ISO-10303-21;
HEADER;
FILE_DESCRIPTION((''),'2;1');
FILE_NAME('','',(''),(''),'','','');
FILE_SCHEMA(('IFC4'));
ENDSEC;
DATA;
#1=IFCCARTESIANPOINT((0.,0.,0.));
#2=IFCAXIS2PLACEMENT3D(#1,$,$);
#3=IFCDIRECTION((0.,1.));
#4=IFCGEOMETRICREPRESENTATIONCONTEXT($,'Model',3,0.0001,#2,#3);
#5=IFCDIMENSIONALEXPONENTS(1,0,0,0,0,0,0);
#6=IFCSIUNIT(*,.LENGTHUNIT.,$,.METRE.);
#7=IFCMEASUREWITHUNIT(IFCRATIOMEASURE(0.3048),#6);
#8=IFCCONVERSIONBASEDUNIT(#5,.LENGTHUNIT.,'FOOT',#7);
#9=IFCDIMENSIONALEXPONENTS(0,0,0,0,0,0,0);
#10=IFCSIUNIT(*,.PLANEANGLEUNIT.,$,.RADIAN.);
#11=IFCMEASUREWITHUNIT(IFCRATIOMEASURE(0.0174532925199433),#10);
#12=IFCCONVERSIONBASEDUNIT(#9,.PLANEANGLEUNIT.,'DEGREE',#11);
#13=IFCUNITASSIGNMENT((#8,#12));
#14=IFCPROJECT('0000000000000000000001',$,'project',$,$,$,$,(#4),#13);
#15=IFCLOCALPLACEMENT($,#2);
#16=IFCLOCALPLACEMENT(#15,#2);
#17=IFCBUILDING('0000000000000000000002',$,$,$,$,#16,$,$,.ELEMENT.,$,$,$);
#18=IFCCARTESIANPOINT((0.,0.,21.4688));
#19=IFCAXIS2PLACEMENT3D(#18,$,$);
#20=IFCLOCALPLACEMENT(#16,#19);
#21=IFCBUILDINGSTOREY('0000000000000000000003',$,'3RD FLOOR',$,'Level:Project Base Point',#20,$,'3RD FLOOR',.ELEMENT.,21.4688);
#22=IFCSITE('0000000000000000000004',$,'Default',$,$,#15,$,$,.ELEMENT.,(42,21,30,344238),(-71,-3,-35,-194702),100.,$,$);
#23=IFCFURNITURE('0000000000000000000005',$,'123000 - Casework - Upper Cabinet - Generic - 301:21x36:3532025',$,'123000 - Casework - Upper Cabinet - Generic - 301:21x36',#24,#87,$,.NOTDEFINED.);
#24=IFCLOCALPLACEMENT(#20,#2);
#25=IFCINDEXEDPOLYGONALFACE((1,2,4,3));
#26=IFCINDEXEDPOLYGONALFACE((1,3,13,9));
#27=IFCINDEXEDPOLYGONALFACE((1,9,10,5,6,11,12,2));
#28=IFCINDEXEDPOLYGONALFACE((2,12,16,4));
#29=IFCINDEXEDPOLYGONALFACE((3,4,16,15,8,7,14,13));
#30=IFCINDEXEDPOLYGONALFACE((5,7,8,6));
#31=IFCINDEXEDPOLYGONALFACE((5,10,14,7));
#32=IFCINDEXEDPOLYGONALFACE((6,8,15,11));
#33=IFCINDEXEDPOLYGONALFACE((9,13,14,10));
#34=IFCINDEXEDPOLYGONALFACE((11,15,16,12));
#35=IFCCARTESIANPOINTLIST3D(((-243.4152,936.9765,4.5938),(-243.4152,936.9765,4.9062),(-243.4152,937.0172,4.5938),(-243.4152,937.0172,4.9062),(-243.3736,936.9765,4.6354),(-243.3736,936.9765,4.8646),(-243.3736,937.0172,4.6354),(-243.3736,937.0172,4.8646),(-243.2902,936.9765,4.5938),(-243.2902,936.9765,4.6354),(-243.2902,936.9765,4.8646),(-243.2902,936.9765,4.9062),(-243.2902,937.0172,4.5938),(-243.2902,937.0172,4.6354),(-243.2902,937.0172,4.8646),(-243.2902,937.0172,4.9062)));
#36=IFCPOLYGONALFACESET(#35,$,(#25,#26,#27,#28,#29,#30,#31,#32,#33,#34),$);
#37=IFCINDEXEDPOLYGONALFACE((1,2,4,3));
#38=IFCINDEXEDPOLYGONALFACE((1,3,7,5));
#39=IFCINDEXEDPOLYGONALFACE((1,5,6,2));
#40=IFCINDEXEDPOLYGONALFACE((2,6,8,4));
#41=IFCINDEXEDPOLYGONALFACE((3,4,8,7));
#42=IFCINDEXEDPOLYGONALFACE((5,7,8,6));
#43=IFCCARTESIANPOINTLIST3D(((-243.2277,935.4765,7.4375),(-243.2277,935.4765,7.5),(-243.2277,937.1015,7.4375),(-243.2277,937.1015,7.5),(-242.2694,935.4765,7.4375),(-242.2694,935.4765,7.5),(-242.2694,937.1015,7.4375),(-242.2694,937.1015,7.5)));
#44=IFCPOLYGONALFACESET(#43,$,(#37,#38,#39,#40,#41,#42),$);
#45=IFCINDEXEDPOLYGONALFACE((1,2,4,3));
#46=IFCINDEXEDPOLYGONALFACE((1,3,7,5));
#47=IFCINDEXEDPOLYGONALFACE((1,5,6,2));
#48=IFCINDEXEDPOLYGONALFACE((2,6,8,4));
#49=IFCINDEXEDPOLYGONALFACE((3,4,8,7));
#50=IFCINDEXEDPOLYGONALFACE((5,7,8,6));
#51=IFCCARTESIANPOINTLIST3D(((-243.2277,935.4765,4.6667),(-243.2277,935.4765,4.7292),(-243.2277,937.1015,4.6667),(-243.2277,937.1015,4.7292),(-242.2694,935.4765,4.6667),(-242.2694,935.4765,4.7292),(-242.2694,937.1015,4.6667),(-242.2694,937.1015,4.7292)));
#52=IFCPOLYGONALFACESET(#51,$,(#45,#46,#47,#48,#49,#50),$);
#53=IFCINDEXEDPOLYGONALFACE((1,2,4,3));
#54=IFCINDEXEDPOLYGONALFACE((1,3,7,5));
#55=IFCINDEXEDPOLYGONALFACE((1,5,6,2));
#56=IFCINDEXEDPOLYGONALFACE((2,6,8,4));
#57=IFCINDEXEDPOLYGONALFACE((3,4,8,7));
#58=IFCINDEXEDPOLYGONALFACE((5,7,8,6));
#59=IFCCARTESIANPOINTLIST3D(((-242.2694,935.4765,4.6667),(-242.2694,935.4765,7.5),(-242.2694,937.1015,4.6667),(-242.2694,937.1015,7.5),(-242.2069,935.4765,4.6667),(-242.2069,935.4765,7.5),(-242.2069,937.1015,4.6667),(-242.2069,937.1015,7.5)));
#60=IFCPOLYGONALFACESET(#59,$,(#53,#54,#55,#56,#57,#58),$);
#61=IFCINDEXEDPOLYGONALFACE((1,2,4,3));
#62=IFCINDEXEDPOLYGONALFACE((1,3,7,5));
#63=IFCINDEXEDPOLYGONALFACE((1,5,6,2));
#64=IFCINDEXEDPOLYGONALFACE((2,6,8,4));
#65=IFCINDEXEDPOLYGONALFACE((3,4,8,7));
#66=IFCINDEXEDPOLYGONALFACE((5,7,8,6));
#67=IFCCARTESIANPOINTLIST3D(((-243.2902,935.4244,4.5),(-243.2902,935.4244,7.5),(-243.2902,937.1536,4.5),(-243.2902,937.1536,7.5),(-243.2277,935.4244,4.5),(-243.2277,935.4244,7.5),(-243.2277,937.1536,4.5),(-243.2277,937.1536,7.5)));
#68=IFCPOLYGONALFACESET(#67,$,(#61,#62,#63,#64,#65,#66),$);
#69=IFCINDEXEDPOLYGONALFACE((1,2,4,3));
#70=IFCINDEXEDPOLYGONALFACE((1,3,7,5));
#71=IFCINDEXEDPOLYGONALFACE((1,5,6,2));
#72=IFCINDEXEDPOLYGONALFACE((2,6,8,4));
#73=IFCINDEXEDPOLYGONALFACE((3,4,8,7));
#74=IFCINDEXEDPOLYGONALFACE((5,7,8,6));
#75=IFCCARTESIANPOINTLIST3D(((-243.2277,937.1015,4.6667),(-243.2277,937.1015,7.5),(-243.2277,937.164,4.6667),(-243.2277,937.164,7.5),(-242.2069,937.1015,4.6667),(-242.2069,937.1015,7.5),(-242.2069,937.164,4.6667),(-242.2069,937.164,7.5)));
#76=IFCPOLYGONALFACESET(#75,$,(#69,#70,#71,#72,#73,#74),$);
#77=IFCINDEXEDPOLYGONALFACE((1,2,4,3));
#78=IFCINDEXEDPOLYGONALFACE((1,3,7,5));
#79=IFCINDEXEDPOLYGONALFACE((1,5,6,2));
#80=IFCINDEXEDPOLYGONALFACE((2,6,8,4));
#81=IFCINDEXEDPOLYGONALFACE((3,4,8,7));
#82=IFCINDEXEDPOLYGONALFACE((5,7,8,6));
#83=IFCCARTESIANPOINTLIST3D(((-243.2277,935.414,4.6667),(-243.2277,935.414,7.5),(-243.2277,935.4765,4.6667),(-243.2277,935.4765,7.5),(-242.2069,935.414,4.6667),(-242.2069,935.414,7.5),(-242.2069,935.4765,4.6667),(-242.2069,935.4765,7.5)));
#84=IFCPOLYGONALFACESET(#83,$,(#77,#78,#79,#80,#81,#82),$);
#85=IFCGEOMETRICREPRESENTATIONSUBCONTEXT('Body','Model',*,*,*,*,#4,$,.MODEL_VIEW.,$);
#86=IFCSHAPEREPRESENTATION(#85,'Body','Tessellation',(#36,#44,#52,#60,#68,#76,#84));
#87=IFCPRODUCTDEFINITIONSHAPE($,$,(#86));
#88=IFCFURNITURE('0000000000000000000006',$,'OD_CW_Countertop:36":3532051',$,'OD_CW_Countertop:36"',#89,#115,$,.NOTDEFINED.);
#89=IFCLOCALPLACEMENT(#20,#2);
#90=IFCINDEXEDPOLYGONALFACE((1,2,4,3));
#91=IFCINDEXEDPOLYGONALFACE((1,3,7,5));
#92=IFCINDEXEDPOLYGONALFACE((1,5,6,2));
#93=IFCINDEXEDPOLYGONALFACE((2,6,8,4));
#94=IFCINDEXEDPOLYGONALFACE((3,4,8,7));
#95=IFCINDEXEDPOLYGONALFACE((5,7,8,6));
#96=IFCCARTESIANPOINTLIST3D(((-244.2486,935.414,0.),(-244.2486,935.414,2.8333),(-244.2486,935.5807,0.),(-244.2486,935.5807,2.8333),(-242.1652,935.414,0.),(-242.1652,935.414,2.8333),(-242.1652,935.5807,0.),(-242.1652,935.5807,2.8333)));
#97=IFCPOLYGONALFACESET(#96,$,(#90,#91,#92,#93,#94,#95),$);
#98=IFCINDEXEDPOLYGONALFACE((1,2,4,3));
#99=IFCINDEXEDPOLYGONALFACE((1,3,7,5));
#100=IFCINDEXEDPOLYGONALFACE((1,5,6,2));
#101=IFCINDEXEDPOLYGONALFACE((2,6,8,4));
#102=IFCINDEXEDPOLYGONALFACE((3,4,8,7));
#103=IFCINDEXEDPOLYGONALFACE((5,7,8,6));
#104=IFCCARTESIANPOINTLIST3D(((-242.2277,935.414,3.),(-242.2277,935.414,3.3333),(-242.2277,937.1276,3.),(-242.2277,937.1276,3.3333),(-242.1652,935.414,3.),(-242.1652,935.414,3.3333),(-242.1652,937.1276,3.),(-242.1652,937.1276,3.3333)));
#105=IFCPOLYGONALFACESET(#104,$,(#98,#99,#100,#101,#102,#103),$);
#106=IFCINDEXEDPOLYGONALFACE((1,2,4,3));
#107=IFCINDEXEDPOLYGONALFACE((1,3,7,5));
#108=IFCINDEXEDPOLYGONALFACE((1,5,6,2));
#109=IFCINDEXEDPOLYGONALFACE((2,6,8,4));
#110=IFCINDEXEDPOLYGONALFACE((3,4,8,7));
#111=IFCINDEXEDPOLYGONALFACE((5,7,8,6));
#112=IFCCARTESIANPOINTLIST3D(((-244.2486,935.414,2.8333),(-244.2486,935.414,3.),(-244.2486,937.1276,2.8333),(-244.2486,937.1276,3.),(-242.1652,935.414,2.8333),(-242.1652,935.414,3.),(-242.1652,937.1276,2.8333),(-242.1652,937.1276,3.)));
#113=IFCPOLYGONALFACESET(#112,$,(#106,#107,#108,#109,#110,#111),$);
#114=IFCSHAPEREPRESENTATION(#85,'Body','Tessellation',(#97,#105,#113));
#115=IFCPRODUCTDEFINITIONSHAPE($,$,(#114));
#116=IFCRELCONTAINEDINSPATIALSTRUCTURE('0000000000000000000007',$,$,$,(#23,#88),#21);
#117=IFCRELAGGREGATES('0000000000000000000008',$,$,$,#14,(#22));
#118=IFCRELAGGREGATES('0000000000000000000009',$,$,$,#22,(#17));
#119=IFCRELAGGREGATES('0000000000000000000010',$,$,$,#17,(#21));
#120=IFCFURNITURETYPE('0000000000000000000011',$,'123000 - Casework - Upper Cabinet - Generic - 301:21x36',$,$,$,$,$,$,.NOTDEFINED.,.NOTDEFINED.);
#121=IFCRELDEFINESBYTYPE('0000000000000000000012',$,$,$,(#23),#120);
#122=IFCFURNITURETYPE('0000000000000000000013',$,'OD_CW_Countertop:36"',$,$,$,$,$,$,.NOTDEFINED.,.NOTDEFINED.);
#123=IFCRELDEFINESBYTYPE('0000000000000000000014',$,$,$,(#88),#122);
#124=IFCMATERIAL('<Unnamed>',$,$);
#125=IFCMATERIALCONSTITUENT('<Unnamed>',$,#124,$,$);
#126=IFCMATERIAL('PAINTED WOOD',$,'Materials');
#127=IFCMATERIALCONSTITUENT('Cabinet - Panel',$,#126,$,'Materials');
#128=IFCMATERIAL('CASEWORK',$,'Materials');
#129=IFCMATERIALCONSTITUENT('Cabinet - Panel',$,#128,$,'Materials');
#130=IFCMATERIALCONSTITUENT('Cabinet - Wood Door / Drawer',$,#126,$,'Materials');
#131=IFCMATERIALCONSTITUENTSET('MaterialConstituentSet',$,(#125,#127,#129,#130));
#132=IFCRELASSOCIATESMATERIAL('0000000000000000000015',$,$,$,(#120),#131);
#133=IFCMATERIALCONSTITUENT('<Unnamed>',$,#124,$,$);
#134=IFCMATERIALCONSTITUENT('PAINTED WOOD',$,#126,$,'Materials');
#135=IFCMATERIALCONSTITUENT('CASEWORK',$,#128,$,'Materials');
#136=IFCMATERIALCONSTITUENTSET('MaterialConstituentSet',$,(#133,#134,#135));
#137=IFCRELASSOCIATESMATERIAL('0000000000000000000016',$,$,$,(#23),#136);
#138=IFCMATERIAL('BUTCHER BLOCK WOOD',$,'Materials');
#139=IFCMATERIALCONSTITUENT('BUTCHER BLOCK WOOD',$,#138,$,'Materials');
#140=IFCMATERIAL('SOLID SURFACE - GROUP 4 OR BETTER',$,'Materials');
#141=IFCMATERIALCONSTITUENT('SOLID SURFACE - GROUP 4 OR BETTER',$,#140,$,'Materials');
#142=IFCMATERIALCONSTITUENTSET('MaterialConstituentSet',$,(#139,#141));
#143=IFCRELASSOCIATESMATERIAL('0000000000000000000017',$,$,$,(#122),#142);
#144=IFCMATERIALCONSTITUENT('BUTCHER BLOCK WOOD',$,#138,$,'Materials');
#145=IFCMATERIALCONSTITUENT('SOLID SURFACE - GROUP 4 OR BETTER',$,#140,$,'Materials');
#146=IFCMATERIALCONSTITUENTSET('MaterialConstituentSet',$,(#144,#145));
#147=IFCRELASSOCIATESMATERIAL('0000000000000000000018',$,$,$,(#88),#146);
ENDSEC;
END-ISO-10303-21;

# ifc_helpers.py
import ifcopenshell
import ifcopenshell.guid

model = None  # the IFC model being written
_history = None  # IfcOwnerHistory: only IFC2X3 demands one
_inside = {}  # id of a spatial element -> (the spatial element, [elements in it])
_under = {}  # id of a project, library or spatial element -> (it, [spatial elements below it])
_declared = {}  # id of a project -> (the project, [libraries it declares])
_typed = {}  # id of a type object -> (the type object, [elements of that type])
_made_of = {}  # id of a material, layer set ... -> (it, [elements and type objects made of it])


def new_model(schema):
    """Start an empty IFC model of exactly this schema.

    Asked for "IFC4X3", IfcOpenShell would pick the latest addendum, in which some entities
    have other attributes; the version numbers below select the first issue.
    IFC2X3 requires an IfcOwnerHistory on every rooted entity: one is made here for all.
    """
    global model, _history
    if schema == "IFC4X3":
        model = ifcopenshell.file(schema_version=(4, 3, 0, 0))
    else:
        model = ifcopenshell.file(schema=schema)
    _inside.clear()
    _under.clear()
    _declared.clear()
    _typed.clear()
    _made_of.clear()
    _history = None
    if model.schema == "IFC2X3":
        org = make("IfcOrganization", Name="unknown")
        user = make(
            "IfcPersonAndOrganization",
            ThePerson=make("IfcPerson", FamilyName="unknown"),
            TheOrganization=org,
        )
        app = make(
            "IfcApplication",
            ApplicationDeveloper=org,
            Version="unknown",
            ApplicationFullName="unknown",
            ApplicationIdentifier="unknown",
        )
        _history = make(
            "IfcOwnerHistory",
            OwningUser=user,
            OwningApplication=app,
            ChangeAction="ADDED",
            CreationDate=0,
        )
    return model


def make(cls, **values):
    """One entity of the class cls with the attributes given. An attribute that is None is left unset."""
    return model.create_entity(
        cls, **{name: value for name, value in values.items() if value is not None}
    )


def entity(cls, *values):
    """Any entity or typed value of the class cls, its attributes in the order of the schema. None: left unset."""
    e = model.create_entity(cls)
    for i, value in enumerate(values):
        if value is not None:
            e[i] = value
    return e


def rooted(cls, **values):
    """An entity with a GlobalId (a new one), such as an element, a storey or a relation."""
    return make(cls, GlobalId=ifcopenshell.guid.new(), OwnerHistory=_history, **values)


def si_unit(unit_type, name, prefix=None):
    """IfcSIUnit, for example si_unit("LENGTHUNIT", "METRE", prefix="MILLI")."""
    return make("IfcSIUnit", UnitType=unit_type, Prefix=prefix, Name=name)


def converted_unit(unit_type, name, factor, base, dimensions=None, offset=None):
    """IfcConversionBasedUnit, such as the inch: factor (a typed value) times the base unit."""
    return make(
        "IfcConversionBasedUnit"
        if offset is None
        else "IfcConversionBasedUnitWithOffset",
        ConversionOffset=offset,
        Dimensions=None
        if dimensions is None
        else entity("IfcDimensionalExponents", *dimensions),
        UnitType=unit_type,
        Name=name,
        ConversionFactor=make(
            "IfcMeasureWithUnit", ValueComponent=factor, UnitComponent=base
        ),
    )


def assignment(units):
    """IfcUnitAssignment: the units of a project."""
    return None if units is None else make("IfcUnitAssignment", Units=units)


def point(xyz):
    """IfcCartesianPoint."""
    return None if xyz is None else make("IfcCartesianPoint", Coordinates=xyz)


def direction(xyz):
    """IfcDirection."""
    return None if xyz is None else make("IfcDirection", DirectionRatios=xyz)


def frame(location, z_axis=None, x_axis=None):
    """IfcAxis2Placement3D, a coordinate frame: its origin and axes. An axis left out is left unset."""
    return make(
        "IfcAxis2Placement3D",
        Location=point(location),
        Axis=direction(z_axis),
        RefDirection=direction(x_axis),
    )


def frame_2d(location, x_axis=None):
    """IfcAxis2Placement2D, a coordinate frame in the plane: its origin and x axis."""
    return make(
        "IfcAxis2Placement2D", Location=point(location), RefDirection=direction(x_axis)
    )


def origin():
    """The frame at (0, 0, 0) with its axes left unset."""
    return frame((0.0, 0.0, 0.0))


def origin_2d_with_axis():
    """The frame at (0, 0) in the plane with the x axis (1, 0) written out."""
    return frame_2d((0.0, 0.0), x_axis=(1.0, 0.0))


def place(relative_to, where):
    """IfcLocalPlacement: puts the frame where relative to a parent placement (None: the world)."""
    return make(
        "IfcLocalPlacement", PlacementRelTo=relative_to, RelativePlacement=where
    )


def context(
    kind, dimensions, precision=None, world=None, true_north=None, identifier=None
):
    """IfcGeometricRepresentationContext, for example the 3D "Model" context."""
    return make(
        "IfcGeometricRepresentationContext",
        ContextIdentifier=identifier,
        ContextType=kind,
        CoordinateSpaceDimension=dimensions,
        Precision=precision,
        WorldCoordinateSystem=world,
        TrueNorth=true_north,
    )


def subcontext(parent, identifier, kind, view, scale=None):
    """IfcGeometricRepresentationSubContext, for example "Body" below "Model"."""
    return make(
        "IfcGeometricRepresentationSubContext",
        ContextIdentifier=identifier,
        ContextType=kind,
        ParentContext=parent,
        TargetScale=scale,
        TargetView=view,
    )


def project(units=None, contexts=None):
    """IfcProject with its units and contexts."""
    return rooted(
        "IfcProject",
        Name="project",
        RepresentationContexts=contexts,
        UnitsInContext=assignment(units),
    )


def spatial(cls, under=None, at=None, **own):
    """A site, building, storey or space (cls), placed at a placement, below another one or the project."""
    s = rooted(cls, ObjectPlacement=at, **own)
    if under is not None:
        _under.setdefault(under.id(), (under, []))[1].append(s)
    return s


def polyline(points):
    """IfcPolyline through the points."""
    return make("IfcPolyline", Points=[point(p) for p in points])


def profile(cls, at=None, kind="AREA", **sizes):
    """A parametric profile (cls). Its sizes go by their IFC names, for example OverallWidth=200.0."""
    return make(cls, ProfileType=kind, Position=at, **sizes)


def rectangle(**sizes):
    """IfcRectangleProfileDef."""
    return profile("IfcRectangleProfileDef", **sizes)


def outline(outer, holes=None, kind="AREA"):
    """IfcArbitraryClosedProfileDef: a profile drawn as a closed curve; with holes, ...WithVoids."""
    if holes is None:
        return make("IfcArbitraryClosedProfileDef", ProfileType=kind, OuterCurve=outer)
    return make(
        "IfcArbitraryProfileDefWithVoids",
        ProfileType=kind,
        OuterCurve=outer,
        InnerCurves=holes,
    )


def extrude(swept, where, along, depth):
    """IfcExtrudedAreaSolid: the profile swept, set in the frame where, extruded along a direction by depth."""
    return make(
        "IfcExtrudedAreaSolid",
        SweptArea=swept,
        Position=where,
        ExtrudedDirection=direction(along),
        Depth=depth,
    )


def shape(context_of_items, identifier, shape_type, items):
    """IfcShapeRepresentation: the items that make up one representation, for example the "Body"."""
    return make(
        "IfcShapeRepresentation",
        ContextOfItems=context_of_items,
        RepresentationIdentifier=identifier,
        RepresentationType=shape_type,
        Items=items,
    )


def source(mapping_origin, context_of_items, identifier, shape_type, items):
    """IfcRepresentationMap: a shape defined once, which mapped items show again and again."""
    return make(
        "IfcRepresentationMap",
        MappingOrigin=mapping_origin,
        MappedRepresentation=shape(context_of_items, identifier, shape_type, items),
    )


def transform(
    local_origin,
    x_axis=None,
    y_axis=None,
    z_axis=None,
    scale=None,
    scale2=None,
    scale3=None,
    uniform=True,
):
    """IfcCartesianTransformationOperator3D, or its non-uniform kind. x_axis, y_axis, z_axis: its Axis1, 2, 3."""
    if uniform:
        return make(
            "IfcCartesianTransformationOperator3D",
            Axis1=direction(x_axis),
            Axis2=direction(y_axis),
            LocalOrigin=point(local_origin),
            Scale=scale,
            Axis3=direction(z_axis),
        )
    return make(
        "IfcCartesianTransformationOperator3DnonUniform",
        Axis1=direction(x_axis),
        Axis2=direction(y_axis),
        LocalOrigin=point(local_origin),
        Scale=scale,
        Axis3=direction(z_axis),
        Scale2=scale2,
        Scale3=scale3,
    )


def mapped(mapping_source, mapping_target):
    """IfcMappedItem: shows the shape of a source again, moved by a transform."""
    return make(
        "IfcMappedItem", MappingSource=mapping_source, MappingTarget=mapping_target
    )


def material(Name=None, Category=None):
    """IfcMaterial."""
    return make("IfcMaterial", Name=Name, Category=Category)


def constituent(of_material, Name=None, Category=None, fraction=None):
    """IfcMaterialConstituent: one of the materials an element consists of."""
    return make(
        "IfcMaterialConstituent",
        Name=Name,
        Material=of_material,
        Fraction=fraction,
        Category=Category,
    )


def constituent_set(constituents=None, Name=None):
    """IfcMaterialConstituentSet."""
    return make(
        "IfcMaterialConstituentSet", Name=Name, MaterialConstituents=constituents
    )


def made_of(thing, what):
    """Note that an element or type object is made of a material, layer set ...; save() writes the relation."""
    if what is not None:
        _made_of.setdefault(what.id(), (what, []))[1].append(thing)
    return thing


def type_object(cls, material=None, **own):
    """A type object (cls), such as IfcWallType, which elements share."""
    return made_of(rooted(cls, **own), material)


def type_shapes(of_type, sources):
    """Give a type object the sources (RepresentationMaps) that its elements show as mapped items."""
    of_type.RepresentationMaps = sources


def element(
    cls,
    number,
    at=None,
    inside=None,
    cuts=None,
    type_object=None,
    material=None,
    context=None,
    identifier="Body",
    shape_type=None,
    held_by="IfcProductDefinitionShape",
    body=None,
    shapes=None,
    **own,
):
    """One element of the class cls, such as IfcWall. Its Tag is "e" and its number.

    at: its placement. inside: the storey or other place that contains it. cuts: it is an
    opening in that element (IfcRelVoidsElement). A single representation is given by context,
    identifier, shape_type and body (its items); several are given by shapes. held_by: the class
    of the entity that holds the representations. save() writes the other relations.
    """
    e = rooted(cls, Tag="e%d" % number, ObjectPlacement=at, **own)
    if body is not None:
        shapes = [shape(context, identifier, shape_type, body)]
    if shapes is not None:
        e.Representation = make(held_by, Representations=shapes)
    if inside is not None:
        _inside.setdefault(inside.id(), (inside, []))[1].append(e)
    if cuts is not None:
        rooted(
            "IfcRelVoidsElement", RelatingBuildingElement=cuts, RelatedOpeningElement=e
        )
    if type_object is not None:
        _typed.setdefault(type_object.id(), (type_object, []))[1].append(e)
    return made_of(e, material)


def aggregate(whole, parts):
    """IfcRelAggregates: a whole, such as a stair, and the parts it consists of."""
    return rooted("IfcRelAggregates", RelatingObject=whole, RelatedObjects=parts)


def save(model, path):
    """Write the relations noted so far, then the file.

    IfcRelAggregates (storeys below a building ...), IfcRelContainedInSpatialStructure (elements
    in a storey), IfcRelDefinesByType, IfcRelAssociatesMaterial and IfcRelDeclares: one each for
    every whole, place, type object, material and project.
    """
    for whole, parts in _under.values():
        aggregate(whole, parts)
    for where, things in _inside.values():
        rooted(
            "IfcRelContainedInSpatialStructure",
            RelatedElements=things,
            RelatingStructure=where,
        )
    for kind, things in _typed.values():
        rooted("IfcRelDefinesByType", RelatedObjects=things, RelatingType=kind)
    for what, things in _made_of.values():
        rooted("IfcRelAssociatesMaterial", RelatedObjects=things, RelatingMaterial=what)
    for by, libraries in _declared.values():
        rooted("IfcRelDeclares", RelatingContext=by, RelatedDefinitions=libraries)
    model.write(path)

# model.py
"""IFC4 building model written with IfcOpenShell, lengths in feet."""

from ifc_helpers import new_model, entity, si_unit, converted_unit, direction, frame, frame_2d, origin, origin_2d_with_axis, place, context, subcontext, project, spatial, polyline, rectangle, outline, extrude, source, transform, mapped, material, constituent, constituent_set, type_object, type_shapes, element, save


model = new_model("IFC4")

# Units and contexts
model_context = context("Model", 3, precision=0.0001, world=origin(), true_north=direction((0.0, 1.0)))
body_context = subcontext(model_context, "Body", "Model", "MODEL_VIEW")
ifc_project = project(units=[converted_unit("LENGTHUNIT", "FOOT", entity("IfcRatioMeasure", 0.3048), si_unit("LENGTHUNIT", "METRE"), dimensions=[1, 0, 0, 0, 0, 0, 0]), converted_unit("PLANEANGLEUNIT", "DEGREE", entity("IfcRatioMeasure", 0.0174532925199433), si_unit("PLANEANGLEUNIT", "RADIAN"), dimensions=[0, 0, 0, 0, 0, 0, 0])], contexts=[model_context])

# Site, building, storey
site_placement = place(None, origin())
site = spatial("IfcSite", under=ifc_project, at=site_placement, Name="Default", CompositionType="ELEMENT", RefLatitude=(42, 21, 30, 344238), RefLongitude=(-71, -3, -35, -194702), RefElevation=100.0)
building_placement = place(site_placement, origin())
building = spatial("IfcBuilding", under=site, at=building_placement, CompositionType="ELEMENT")
storey_placement = place(building_placement, frame((0.0, 0.0, 21.4688)))
storey = spatial("IfcBuildingStorey", under=building, at=storey_placement, Name="3RD FLOOR", ObjectType="Level:Project Base Point", LongName="3RD FLOOR", CompositionType="ELEMENT", Elevation=21.4688)

# Furniture
ifc_material_1 = material(Name="CASEWORK", Category="Materials")
ifc_material_2 = material(Name="<Unnamed>")
ifc_material_3 = material(Name="PAINTED WOOD", Category="Materials")
ifc_material_4 = material(Name="SOLID SURFACE - GROUP 4 OR BETTER", Category="Materials")
ifc_material_5 = material(Name="BUTCHER BLOCK WOOD", Category="Materials")
ifc_constituent_1 = constituent(ifc_material_2, Name="<Unnamed>")
ifc_constituent_2 = constituent(ifc_material_3, Name="PAINTED WOOD", Category="Materials")
ifc_constituent_3 = constituent(ifc_material_1, Name="CASEWORK", Category="Materials")
ifc_constituent_set_1 = constituent_set(constituents=[ifc_constituent_1, ifc_constituent_2, ifc_constituent_3], Name="MaterialConstituentSet")
ifc_constituent_4 = constituent(ifc_material_2, Name="<Unnamed>")
ifc_constituent_5 = constituent(ifc_material_3, Name="Cabinet - Panel", Category="Materials")
ifc_constituent_6 = constituent(ifc_material_1, Name="Cabinet - Panel", Category="Materials")
ifc_constituent_7 = constituent(ifc_material_3, Name="Cabinet - Wood Door / Drawer", Category="Materials")
ifc_constituent_set_2 = constituent_set(constituents=[ifc_constituent_4, ifc_constituent_5, ifc_constituent_6, ifc_constituent_7], Name="MaterialConstituentSet")
furniture_type_1 = type_object("IfcFurnitureType", Name="123000 - Casework - Upper Cabinet - Generic - 301:21x36", AssemblyPlace="NOTDEFINED", PredefinedType="NOTDEFINED", material=ifc_constituent_set_2)
shared_shape_1 = source(origin(), body_context, "Body", "SweptSolid", [
    extrude(outline(polyline([(0.1146, -0.0521), (0.1562, -0.0521), (0.1562, 0.0729), (-0.1562, 0.0729), (-0.1562, -0.0521), (-0.1146, -0.0521), (-0.1146, 0.0313), (0.1146, 0.0313), (0.1146, -0.0521)])), frame((0.1468, 0.0729, 0.25), z_axis=(1.0, 0.0, 0.0), x_axis=(0.0, 0.0, 1.0)), (0.0, 0.0, 1.0), 0.0407),
    extrude(rectangle(XDim=1.625, YDim=0.9583, at=frame_2d((0.0, 0.0), x_axis=(1.0, 0.0))), frame((0.875, 0.6666, 2.9375), z_axis=(0.0, 0.0, 1.0), x_axis=(-1.0, 0.0, 0.0)), (0.0, 0.0, 1.0), 0.0625),
    extrude(rectangle(XDim=1.625, YDim=0.9583, at=frame_2d((0.0, 0.0), x_axis=(1.0, 0.0))), frame((0.875, 0.6666, 0.1667), z_axis=(0.0, 0.0, 1.0), x_axis=(-1.0, 0.0, 0.0)), (0.0, 0.0, 1.0), 0.0625),
    extrude(rectangle(XDim=0.0625, YDim=1.625, at=origin_2d_with_axis()), frame((0.875, 1.177, 0.1667), z_axis=(0.0, 0.0, 1.0), x_axis=(0.0, 1.0, 0.0)), (0.0, 0.0, 1.0), 2.8333),
    extrude(rectangle(XDim=0.0625, YDim=1.7292, at=frame_2d((0.0, 0.0), x_axis=(1.0, 0.0))), frame((0.875, 0.1562, 0.0), z_axis=(0.0, 0.0, 1.0), x_axis=(0.0, -1.0, 0.0)), (0.0, 0.0, 1.0), 3.0),
    extrude(rectangle(XDim=0.0625, YDim=1.0208, at=origin_2d_with_axis()), frame((0.0312, 0.6979, 0.1667), z_axis=(0.0, 0.0, 1.0), x_axis=(-1.0, 0.0, 0.0)), (0.0, 0.0, 1.0), 2.8333),
    extrude(rectangle(XDim=0.0625, YDim=1.0208, at=origin_2d_with_axis()), frame((1.7188, 0.6979, 0.1667), z_axis=(0.0, 0.0, 1.0), x_axis=(-1.0, 0.0, 0.0)), (0.0, 0.0, 1.0), 2.8333),
])
type_shapes(furniture_type_1, [shared_shape_1])
furniture_1_placement = place(storey_placement, frame((-243.4152, 937.164, 4.5), z_axis=(0.0, 0.0, 1.0), x_axis=(0.0, -1.0, 0.0)))
element("IfcFurniture", 1, at=furniture_1_placement, inside=storey, type_object=furniture_type_1, material=ifc_constituent_set_1, Name="123000 - Casework - Upper Cabinet - Generic - 301:21x36:3532025", ObjectType="123000 - Casework - Upper Cabinet - Generic - 301:21x36", PredefinedType="NOTDEFINED", context=body_context, shape_type="MappedRepresentation", body=[
    mapped(shared_shape_1, transform((0.0, 0.0, 0.0), scale=1.0)),
])
ifc_constituent_8 = constituent(ifc_material_5, Name="BUTCHER BLOCK WOOD", Category="Materials")
ifc_constituent_9 = constituent(ifc_material_4, Name="SOLID SURFACE - GROUP 4 OR BETTER", Category="Materials")
ifc_constituent_set_3 = constituent_set(constituents=[ifc_constituent_8, ifc_constituent_9], Name="MaterialConstituentSet")
ifc_constituent_10 = constituent(ifc_material_5, Name="BUTCHER BLOCK WOOD", Category="Materials")
ifc_constituent_11 = constituent(ifc_material_4, Name="SOLID SURFACE - GROUP 4 OR BETTER", Category="Materials")
ifc_constituent_set_4 = constituent_set(constituents=[ifc_constituent_10, ifc_constituent_11], Name="MaterialConstituentSet")
furniture_type_2 = type_object("IfcFurnitureType", Name="OD_CW_Countertop:36\"", AssemblyPlace="NOTDEFINED", PredefinedType="NOTDEFINED", material=ifc_constituent_set_4)
shared_shape_2 = source(origin(), body_context, "Body", "SweptSolid", [
    extrude(rectangle(XDim=0.1667, YDim=2.0833, at=frame_2d((0.0, 0.0), x_axis=(1.0, 0.0))), frame((0.0833, 1.0417, 0.0)), (0.0, 0.0, 1.0), 2.8333),
    extrude(rectangle(XDim=1.7135, YDim=0.0625, at=origin_2d_with_axis()), frame((0.8568, 0.0313, 3.0)), (0.0, 0.0, 1.0), 0.3333),
    extrude(rectangle(XDim=1.7135, YDim=2.0833, at=origin_2d_with_axis()), frame((0.8568, 1.0417, 2.8333)), (0.0, 0.0, 1.0), 0.1667),
])
type_shapes(furniture_type_2, [shared_shape_2])
furniture_2_placement = place(storey_placement, frame((-242.1652, 935.414, 0.0), z_axis=(0.0, 0.0, 1.0), x_axis=(0.0, 1.0, 0.0)))
element("IfcFurniture", 2, at=furniture_2_placement, inside=storey, type_object=furniture_type_2, material=ifc_constituent_set_3, Name="OD_CW_Countertop:36\":3532051", ObjectType="OD_CW_Countertop:36\"", PredefinedType="NOTDEFINED", context=body_context, shape_type="MappedRepresentation", body=[
    mapped(shared_shape_2, transform((0.0, 0.0, 0.0), scale=1.0)),
])

save(model, "model.ifc")
